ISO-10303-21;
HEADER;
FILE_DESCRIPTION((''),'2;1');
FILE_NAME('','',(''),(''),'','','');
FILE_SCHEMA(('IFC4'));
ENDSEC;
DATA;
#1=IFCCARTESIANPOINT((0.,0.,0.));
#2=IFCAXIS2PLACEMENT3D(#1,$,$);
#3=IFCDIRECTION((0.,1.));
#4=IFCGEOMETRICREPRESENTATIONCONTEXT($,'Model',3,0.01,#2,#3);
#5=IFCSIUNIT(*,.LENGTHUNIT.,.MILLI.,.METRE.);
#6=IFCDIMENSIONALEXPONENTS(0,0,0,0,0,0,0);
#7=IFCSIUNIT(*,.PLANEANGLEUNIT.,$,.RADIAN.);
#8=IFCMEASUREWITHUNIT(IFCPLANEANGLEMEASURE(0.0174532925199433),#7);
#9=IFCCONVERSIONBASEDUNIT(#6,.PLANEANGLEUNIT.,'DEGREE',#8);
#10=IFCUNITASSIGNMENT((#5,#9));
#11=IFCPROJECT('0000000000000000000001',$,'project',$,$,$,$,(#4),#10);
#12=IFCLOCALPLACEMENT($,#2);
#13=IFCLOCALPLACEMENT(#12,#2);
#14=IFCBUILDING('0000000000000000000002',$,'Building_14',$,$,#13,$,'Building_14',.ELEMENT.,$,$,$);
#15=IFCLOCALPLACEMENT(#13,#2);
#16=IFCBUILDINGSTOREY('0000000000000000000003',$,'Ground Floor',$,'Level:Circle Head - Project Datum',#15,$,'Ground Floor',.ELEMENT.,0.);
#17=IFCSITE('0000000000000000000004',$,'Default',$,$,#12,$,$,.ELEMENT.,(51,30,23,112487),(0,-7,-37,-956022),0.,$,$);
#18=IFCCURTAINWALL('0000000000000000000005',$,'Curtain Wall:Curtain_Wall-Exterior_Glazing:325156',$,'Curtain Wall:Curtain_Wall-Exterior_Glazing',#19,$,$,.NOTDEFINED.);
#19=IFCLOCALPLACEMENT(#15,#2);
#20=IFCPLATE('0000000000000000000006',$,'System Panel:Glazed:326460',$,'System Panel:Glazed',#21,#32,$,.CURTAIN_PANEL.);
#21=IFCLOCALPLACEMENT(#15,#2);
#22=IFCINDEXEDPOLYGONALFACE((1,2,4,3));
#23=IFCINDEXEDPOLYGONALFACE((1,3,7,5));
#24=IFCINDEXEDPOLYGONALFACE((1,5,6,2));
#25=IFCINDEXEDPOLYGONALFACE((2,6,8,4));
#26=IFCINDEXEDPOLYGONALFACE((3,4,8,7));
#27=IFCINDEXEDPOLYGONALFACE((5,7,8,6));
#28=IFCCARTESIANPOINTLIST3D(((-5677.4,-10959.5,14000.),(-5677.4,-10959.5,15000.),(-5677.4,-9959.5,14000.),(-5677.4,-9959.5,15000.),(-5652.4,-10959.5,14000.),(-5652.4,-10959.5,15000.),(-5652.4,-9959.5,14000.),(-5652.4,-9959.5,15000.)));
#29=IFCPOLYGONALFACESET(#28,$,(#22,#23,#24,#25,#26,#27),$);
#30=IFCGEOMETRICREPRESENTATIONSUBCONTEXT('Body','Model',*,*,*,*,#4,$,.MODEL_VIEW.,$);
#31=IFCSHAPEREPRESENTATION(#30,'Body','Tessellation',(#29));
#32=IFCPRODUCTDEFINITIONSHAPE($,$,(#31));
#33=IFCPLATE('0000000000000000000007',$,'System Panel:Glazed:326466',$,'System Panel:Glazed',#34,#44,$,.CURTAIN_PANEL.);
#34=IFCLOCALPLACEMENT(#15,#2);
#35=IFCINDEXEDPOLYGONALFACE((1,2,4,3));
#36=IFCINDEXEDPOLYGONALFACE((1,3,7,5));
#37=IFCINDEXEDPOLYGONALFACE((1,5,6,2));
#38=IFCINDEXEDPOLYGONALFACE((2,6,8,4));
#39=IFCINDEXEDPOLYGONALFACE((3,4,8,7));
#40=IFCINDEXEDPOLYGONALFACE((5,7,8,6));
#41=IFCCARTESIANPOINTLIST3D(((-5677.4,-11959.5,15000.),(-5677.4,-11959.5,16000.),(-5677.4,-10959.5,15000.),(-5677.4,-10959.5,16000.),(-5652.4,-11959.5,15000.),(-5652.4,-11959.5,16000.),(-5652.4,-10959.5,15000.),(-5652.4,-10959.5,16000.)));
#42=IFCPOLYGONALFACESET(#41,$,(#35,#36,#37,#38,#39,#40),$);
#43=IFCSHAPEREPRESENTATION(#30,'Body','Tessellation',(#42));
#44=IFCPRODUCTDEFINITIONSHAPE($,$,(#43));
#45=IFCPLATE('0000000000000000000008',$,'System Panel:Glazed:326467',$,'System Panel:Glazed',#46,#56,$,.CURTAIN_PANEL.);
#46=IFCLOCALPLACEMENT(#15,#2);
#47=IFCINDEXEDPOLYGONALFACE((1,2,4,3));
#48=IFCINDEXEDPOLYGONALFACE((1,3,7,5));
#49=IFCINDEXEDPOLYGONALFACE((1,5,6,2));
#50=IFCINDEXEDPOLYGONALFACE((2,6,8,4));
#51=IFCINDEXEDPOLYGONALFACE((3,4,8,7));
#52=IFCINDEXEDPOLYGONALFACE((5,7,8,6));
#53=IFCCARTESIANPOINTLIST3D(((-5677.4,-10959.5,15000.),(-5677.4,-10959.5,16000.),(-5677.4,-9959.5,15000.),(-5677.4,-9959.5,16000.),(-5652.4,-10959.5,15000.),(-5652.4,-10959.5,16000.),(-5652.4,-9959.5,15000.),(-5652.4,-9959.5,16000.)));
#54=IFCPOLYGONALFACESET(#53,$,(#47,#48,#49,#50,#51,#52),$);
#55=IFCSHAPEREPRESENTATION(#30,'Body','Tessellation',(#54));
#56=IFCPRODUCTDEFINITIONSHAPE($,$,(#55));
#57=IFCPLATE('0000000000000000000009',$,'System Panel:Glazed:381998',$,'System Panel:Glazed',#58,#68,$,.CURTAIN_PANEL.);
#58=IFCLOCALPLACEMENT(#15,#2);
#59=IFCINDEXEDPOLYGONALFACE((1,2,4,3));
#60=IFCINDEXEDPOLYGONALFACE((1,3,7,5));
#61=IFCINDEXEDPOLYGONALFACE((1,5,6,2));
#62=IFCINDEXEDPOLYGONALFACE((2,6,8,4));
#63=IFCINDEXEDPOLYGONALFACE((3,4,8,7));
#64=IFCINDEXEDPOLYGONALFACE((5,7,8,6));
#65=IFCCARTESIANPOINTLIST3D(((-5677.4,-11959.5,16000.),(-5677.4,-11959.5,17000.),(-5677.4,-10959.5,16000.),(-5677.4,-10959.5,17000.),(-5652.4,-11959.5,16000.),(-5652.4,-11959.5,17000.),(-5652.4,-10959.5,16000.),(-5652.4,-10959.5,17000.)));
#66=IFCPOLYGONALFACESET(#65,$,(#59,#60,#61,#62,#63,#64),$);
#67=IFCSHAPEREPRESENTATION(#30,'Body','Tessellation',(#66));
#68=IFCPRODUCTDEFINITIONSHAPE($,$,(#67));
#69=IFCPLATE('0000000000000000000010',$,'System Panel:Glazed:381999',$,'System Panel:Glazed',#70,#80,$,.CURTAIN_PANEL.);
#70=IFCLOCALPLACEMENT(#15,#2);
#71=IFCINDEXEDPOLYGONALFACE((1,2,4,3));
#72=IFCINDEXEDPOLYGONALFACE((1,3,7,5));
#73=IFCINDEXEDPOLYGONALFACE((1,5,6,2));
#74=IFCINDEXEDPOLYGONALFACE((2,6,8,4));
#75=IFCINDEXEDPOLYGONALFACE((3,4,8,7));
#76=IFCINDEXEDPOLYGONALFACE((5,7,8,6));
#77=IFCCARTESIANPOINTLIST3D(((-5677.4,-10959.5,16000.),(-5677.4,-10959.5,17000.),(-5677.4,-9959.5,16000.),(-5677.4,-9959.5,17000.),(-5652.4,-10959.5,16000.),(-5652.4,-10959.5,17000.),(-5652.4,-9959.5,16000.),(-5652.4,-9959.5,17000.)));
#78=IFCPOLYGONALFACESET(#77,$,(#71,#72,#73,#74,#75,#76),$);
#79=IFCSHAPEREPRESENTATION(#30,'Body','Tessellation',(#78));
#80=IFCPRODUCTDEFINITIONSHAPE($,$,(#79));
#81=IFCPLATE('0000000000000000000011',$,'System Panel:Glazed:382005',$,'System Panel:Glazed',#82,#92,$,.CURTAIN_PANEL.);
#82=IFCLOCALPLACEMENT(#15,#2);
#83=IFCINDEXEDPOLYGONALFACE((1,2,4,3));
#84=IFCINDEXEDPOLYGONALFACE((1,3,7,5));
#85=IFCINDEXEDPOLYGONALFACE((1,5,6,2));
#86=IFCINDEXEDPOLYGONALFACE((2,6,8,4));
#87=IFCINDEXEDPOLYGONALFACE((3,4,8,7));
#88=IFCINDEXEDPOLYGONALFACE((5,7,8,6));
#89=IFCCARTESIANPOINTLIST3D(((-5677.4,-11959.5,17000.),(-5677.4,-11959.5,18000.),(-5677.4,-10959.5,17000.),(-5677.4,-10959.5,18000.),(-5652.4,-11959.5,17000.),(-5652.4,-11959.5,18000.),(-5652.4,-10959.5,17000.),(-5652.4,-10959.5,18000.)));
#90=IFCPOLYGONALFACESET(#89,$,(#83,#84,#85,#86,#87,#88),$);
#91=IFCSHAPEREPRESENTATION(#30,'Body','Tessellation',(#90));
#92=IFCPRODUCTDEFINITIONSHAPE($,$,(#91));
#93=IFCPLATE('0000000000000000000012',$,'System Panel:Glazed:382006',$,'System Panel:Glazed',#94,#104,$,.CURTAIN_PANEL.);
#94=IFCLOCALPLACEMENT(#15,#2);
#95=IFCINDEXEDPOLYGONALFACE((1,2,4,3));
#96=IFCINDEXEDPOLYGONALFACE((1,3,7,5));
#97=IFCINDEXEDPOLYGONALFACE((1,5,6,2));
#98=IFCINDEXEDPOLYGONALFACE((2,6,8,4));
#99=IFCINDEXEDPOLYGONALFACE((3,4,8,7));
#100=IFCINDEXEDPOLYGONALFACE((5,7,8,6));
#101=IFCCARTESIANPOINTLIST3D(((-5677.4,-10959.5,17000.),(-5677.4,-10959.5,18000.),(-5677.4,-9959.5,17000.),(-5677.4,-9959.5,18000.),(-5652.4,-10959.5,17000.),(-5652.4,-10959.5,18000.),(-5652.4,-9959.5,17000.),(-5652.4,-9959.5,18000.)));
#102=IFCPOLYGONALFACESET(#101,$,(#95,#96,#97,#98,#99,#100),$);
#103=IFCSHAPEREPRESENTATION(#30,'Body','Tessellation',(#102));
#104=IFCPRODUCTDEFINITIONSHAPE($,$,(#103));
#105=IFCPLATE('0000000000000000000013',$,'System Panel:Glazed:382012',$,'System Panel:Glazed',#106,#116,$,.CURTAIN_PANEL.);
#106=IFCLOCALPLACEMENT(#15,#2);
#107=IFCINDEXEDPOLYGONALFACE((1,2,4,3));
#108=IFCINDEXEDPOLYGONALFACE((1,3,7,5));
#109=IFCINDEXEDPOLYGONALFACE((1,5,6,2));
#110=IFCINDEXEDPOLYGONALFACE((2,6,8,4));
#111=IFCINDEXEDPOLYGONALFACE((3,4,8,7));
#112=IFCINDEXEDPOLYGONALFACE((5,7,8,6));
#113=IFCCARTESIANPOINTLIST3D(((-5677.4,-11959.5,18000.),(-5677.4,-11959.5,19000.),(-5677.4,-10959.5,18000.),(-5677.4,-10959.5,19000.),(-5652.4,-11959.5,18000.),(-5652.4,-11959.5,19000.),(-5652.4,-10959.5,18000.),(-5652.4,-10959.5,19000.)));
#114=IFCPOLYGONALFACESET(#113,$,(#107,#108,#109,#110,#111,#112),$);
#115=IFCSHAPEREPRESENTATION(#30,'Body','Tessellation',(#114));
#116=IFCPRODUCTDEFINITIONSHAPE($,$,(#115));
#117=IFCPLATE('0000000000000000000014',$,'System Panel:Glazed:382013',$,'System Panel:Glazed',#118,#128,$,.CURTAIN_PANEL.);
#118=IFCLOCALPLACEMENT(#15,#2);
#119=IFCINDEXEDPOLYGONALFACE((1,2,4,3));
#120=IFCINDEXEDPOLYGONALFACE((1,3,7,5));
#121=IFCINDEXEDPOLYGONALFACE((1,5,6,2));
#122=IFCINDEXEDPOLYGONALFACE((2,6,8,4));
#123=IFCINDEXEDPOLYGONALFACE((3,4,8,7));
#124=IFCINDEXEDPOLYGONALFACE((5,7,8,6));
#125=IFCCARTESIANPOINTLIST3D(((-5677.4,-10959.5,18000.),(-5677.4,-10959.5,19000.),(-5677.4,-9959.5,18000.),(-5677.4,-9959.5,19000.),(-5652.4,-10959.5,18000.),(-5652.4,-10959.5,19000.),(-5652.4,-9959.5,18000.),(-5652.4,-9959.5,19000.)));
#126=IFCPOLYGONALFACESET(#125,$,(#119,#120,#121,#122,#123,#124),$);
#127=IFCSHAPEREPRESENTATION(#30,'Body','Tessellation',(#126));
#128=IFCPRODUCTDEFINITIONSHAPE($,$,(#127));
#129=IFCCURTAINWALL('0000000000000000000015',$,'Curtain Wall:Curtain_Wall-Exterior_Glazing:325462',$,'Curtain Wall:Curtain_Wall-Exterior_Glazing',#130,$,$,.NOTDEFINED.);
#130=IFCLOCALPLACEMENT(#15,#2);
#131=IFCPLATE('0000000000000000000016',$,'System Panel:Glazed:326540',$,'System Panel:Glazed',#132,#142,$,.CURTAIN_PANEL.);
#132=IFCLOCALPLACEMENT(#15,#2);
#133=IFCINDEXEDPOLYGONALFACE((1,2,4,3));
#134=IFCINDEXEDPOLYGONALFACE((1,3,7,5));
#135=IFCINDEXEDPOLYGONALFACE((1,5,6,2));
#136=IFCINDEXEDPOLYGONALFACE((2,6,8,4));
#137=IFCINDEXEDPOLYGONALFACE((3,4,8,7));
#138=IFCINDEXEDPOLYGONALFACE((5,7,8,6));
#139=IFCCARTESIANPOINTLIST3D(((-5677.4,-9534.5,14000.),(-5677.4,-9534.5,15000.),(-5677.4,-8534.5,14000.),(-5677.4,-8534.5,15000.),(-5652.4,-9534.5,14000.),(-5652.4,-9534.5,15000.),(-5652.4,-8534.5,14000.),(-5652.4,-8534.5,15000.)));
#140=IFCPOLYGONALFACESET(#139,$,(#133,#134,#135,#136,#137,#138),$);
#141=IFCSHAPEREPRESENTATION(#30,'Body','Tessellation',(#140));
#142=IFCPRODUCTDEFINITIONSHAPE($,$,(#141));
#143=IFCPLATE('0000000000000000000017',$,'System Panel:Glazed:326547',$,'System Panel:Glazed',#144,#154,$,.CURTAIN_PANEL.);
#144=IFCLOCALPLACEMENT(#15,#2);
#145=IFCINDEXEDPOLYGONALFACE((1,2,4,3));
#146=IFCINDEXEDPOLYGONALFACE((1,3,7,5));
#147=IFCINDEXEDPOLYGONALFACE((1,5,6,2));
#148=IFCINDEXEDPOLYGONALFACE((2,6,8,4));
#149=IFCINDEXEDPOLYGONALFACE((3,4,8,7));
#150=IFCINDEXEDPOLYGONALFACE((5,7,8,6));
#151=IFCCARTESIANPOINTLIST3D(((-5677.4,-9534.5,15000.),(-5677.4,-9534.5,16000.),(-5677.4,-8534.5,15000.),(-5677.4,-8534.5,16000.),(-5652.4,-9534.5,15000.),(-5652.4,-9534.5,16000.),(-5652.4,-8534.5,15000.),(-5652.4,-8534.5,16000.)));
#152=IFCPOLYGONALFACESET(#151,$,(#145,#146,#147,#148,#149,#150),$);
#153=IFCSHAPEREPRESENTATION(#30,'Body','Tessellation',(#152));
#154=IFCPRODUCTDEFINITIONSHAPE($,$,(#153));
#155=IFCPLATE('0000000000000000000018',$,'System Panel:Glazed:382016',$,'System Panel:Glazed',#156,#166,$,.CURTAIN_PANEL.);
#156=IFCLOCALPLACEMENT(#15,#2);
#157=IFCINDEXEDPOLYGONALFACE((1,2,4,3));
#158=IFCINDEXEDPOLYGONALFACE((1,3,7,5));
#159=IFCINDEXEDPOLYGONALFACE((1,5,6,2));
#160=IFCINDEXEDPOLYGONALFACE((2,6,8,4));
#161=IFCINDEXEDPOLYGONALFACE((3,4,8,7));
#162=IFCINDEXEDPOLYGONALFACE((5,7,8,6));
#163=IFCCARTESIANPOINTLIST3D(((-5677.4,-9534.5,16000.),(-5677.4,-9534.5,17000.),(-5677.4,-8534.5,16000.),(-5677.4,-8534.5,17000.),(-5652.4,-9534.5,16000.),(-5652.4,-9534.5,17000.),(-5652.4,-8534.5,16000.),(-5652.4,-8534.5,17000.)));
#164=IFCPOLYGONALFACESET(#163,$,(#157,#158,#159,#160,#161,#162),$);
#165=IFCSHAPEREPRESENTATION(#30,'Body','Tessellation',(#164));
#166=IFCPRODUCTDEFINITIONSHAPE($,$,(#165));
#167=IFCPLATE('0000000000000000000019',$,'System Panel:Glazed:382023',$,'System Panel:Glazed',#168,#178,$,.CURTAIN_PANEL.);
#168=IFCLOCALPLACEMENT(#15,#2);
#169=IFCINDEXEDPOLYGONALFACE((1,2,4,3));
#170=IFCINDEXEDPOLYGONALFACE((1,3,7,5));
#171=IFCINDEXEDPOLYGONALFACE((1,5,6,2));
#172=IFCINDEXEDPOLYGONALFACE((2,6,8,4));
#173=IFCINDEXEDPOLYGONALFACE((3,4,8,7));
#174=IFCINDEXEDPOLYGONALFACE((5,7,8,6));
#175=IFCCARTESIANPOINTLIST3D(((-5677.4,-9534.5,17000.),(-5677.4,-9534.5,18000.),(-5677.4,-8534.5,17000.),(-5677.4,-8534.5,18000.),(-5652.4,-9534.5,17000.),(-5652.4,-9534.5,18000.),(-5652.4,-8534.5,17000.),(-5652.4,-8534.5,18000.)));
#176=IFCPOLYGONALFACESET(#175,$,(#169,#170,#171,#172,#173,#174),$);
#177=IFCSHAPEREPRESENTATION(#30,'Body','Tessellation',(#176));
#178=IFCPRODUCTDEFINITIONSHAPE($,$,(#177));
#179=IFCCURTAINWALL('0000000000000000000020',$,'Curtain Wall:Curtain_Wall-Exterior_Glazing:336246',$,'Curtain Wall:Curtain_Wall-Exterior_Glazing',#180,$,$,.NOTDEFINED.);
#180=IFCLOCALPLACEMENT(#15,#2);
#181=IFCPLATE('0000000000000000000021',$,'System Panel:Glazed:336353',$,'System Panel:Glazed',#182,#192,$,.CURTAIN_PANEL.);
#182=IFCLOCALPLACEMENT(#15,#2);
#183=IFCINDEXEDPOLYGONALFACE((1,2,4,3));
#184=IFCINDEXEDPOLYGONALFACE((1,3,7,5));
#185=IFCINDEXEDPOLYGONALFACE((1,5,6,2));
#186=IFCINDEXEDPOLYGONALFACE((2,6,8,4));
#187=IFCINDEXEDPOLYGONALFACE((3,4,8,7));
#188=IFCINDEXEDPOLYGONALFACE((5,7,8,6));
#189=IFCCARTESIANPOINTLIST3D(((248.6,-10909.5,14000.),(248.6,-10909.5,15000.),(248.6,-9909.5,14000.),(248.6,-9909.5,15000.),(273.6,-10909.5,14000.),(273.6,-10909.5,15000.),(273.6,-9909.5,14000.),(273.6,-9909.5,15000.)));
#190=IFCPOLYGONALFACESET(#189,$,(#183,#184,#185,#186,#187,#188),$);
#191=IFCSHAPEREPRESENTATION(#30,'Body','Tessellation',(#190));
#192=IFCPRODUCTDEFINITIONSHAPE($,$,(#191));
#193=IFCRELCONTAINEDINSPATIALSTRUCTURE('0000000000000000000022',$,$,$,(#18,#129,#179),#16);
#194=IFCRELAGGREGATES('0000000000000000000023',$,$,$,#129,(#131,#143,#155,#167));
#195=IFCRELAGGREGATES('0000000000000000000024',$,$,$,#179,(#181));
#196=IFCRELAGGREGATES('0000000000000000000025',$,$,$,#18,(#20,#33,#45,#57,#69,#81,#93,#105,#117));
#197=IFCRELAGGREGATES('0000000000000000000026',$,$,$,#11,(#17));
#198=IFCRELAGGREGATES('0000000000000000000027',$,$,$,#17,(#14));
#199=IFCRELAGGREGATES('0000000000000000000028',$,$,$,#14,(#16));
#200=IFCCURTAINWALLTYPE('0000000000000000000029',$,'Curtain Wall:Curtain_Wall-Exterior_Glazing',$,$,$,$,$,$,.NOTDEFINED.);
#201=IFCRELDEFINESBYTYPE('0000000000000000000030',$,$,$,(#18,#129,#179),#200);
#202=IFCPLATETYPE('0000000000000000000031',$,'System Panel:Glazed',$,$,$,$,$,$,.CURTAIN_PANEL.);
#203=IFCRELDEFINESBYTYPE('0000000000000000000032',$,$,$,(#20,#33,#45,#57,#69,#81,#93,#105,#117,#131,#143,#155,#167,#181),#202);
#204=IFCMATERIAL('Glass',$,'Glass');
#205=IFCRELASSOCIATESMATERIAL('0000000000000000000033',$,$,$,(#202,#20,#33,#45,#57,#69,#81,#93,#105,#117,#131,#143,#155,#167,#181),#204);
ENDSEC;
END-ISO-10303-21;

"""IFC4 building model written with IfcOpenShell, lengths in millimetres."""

from ifc_helpers import new_model, entity, si_unit, converted_unit, direction, frame, origin, place, context, subcontext, project, spatial, indexed_curve, outline, extrude, source, transform, mapped, material, type_object, type_shapes, element, aggregate, save


model = new_model("IFC4")

# Units and contexts
model_context = context("Model", 3, precision=0.01, world=origin(), true_north=direction((0.0, 1.0)))
body_context = subcontext(model_context, "Body", "Model", "MODEL_VIEW")
ifc_project = project(units=[si_unit("LENGTHUNIT", "METRE", prefix="MILLI"), converted_unit("PLANEANGLEUNIT", "DEGREE", entity("IfcPlaneAngleMeasure", 0.0174532925199433), si_unit("PLANEANGLEUNIT", "RADIAN"), dimensions=[0, 0, 0, 0, 0, 0, 0])], contexts=[model_context])

# Site, building, storey
site_placement = place(None, origin())
site = spatial("IfcSite", under=ifc_project, at=site_placement, Name="Default", CompositionType="ELEMENT", RefLatitude=(51, 30, 23, 112487), RefLongitude=(0, -7, -37, -956022), RefElevation=0.0)
building_placement = place(site_placement, origin())
building = spatial("IfcBuilding", under=site, at=building_placement, Name="Building_14", LongName="Building_14", CompositionType="ELEMENT")
storey_placement = place(building_placement, origin())
storey = spatial("IfcBuildingStorey", under=building, at=storey_placement, Name="Ground Floor", ObjectType="Level:Circle Head - Project Datum", LongName="Ground Floor", CompositionType="ELEMENT", Elevation=0.0)

# Curtain walls, plates
curtain_wall_type = type_object("IfcCurtainWallType", Name="Curtain Wall:Curtain_Wall-Exterior_Glazing", PredefinedType="NOTDEFINED")
curtain_wall_1_placement = place(storey_placement, origin())
curtain_wall_1 = element("IfcCurtainWall", 1, at=curtain_wall_1_placement, inside=storey, type_object=curtain_wall_type, Name="Curtain Wall:Curtain_Wall-Exterior_Glazing:325156", ObjectType="Curtain Wall:Curtain_Wall-Exterior_Glazing", PredefinedType="NOTDEFINED")
ifc_material = material(Name="Glass", Category="Glass")
plate_type_1 = type_object("IfcPlateType", Name="System Panel:Glazed", PredefinedType="CURTAIN_PANEL", material=ifc_material)
shared_shape_1 = source(origin(), body_context, "Body", "SweptSolid", [
    extrude(outline(indexed_curve([(-12.5, -500.0), (12.5, -500.0), (12.5, 500.0), (-12.5, 500.0), (-12.5, -500.0)], self_intersect=False)), frame((0.0, -37.0, 0.0), z_axis=(0.0, 0.0, 1.0), x_axis=(0.0, 1.0, 0.0)), (0.0, 0.0, 1.0), 1000.0),
])
type_shapes(plate_type_1, [shared_shape_1])
plate_1_placement = place(curtain_wall_1_placement, frame((-5701.9, -10459.5, 14000.0), z_axis=(0.0, 0.0, 1.0), x_axis=(0.0, 1.0, 0.0)))
plate_1 = element("IfcPlate", 2, at=plate_1_placement, type_object=plate_type_1, material=ifc_material, Name="System Panel:Glazed:326460", ObjectType="System Panel:Glazed", PredefinedType="CURTAIN_PANEL", context=body_context, shape_type="MappedRepresentation", body=[
    mapped(shared_shape_1, transform((0.0, 0.0, 0.0), scale=1.0)),
])
plate_2_placement = place(curtain_wall_1_placement, frame((-5701.9, -11459.5, 15000.0), z_axis=(0.0, 0.0, 1.0), x_axis=(0.0, 1.0, 0.0)))
plate_2 = element("IfcPlate", 3, at=plate_2_placement, type_object=plate_type_1, material=ifc_material, Name="System Panel:Glazed:326466", ObjectType="System Panel:Glazed", PredefinedType="CURTAIN_PANEL", context=body_context, shape_type="MappedRepresentation", body=[
    mapped(shared_shape_1, transform((0.0, 0.0, 0.0), scale=1.0)),
])
plate_3_placement = place(curtain_wall_1_placement, frame((-5701.9, -10459.5, 15000.0), z_axis=(0.0, 0.0, 1.0), x_axis=(0.0, 1.0, 0.0)))
plate_3 = element("IfcPlate", 4, at=plate_3_placement, type_object=plate_type_1, material=ifc_material, Name="System Panel:Glazed:326467", ObjectType="System Panel:Glazed", PredefinedType="CURTAIN_PANEL", context=body_context, shape_type="MappedRepresentation", body=[
    mapped(shared_shape_1, transform((0.0, 0.0, 0.0), scale=1.0)),
])
plate_4_placement = place(curtain_wall_1_placement, frame((-5701.9, -11459.5, 16000.0), z_axis=(0.0, 0.0, 1.0), x_axis=(0.0, 1.0, 0.0)))
plate_4 = element("IfcPlate", 5, at=plate_4_placement, type_object=plate_type_1, material=ifc_material, Name="System Panel:Glazed:381998", ObjectType="System Panel:Glazed", PredefinedType="CURTAIN_PANEL", context=body_context, shape_type="MappedRepresentation", body=[
    mapped(shared_shape_1, transform((0.0, 0.0, 0.0), scale=1.0)),
])
plate_5_placement = place(curtain_wall_1_placement, frame((-5701.9, -10459.5, 16000.0), z_axis=(0.0, 0.0, 1.0), x_axis=(0.0, 1.0, 0.0)))
plate_5 = element("IfcPlate", 6, at=plate_5_placement, type_object=plate_type_1, material=ifc_material, Name="System Panel:Glazed:381999", ObjectType="System Panel:Glazed", PredefinedType="CURTAIN_PANEL", context=body_context, shape_type="MappedRepresentation", body=[
    mapped(shared_shape_1, transform((0.0, 0.0, 0.0), scale=1.0)),
])
plate_6_placement = place(curtain_wall_1_placement, frame((-5701.9, -11459.5, 17000.0), z_axis=(0.0, 0.0, 1.0), x_axis=(0.0, 1.0, 0.0)))
plate_6 = element("IfcPlate", 7, at=plate_6_placement, type_object=plate_type_1, material=ifc_material, Name="System Panel:Glazed:382005", ObjectType="System Panel:Glazed", PredefinedType="CURTAIN_PANEL", context=body_context, shape_type="MappedRepresentation", body=[
    mapped(shared_shape_1, transform((0.0, 0.0, 0.0), scale=1.0)),
])
plate_7_placement = place(curtain_wall_1_placement, frame((-5701.9, -10459.5, 17000.0), z_axis=(0.0, 0.0, 1.0), x_axis=(0.0, 1.0, 0.0)))
plate_7 = element("IfcPlate", 8, at=plate_7_placement, type_object=plate_type_1, material=ifc_material, Name="System Panel:Glazed:382006", ObjectType="System Panel:Glazed", PredefinedType="CURTAIN_PANEL", context=body_context, shape_type="MappedRepresentation", body=[
    mapped(shared_shape_1, transform((0.0, 0.0, 0.0), scale=1.0)),
])
plate_8_placement = place(curtain_wall_1_placement, frame((-5701.9, -11459.5, 18000.0), z_axis=(0.0, 0.0, 1.0), x_axis=(0.0, 1.0, 0.0)))
plate_8 = element("IfcPlate", 9, at=plate_8_placement, type_object=plate_type_1, material=ifc_material, Name="System Panel:Glazed:382012", ObjectType="System Panel:Glazed", PredefinedType="CURTAIN_PANEL", context=body_context, shape_type="MappedRepresentation", body=[
    mapped(shared_shape_1, transform((0.0, 0.0, 0.0), scale=1.0)),
])
plate_9_placement = place(curtain_wall_1_placement, frame((-5701.9, -10459.5, 18000.0), z_axis=(0.0, 0.0, 1.0), x_axis=(0.0, 1.0, 0.0)))
plate_9 = element("IfcPlate", 10, at=plate_9_placement, type_object=plate_type_1, material=ifc_material, Name="System Panel:Glazed:382013", ObjectType="System Panel:Glazed", PredefinedType="CURTAIN_PANEL", context=body_context, shape_type="MappedRepresentation", body=[
    mapped(shared_shape_1, transform((0.0, 0.0, 0.0), scale=1.0)),
])
curtain_wall_2_placement = place(storey_placement, origin())
curtain_wall_2 = element("IfcCurtainWall", 11, at=curtain_wall_2_placement, inside=storey, type_object=curtain_wall_type, Name="Curtain Wall:Curtain_Wall-Exterior_Glazing:325462", ObjectType="Curtain Wall:Curtain_Wall-Exterior_Glazing", PredefinedType="NOTDEFINED")
plate_10_placement = place(curtain_wall_2_placement, frame((-5701.9, -9034.5, 14000.0), z_axis=(0.0, 0.0, 1.0), x_axis=(0.0, 1.0, 0.0)))
plate_10 = element("IfcPlate", 12, at=plate_10_placement, type_object=plate_type_1, material=ifc_material, Name="System Panel:Glazed:326540", ObjectType="System Panel:Glazed", PredefinedType="CURTAIN_PANEL", context=body_context, shape_type="MappedRepresentation", body=[
    mapped(shared_shape_1, transform((0.0, 0.0, 0.0), scale=1.0)),
])
plate_11_placement = place(curtain_wall_2_placement, frame((-5701.9, -9034.5, 15000.0), z_axis=(0.0, 0.0, 1.0), x_axis=(0.0, 1.0, 0.0)))
plate_11 = element("IfcPlate", 13, at=plate_11_placement, type_object=plate_type_1, material=ifc_material, Name="System Panel:Glazed:326547", ObjectType="System Panel:Glazed", PredefinedType="CURTAIN_PANEL", context=body_context, shape_type="MappedRepresentation", body=[
    mapped(shared_shape_1, transform((0.0, 0.0, 0.0), scale=1.0)),
])
plate_12_placement = place(curtain_wall_2_placement, frame((-5701.9, -9034.5, 16000.0), z_axis=(0.0, 0.0, 1.0), x_axis=(0.0, 1.0, 0.0)))
plate_12 = element("IfcPlate", 14, at=plate_12_placement, type_object=plate_type_1, material=ifc_material, Name="System Panel:Glazed:382016", ObjectType="System Panel:Glazed", PredefinedType="CURTAIN_PANEL", context=body_context, shape_type="MappedRepresentation", body=[
    mapped(shared_shape_1, transform((0.0, 0.0, 0.0), scale=1.0)),
])
plate_13_placement = place(curtain_wall_2_placement, frame((-5701.9, -9034.5, 17000.0), z_axis=(0.0, 0.0, 1.0), x_axis=(0.0, 1.0, 0.0)))
plate_13 = element("IfcPlate", 15, at=plate_13_placement, type_object=plate_type_1, material=ifc_material, Name="System Panel:Glazed:382023", ObjectType="System Panel:Glazed", PredefinedType="CURTAIN_PANEL", context=body_context, shape_type="MappedRepresentation", body=[
    mapped(shared_shape_1, transform((0.0, 0.0, 0.0), scale=1.0)),
])
aggregate(curtain_wall_2, [plate_10, plate_11, plate_12, plate_13])
curtain_wall_3_placement = place(storey_placement, origin())
curtain_wall_3 = element("IfcCurtainWall", 16, at=curtain_wall_3_placement, inside=storey, type_object=curtain_wall_type, Name="Curtain Wall:Curtain_Wall-Exterior_Glazing:336246", ObjectType="Curtain Wall:Curtain_Wall-Exterior_Glazing", PredefinedType="NOTDEFINED")
plate_14_placement = place(curtain_wall_3_placement, frame((298.1, -10409.5, 14000.0), z_axis=(0.0, 0.0, 1.0), x_axis=(0.0, -1.0, 0.0)))
plate_14 = element("IfcPlate", 17, at=plate_14_placement, type_object=plate_type_1, material=ifc_material, Name="System Panel:Glazed:336353", ObjectType="System Panel:Glazed", PredefinedType="CURTAIN_PANEL", context=body_context, shape_type="MappedRepresentation", body=[
    mapped(shared_shape_1, transform((0.0, 0.0, 0.0), scale=1.0)),
])
aggregate(curtain_wall_3, [plate_14])

aggregate(curtain_wall_1, [plate_1, plate_2, plate_3, plate_4, plate_5, plate_6, plate_7, plate_8, plate_9])

save(model, "model.ifc")
